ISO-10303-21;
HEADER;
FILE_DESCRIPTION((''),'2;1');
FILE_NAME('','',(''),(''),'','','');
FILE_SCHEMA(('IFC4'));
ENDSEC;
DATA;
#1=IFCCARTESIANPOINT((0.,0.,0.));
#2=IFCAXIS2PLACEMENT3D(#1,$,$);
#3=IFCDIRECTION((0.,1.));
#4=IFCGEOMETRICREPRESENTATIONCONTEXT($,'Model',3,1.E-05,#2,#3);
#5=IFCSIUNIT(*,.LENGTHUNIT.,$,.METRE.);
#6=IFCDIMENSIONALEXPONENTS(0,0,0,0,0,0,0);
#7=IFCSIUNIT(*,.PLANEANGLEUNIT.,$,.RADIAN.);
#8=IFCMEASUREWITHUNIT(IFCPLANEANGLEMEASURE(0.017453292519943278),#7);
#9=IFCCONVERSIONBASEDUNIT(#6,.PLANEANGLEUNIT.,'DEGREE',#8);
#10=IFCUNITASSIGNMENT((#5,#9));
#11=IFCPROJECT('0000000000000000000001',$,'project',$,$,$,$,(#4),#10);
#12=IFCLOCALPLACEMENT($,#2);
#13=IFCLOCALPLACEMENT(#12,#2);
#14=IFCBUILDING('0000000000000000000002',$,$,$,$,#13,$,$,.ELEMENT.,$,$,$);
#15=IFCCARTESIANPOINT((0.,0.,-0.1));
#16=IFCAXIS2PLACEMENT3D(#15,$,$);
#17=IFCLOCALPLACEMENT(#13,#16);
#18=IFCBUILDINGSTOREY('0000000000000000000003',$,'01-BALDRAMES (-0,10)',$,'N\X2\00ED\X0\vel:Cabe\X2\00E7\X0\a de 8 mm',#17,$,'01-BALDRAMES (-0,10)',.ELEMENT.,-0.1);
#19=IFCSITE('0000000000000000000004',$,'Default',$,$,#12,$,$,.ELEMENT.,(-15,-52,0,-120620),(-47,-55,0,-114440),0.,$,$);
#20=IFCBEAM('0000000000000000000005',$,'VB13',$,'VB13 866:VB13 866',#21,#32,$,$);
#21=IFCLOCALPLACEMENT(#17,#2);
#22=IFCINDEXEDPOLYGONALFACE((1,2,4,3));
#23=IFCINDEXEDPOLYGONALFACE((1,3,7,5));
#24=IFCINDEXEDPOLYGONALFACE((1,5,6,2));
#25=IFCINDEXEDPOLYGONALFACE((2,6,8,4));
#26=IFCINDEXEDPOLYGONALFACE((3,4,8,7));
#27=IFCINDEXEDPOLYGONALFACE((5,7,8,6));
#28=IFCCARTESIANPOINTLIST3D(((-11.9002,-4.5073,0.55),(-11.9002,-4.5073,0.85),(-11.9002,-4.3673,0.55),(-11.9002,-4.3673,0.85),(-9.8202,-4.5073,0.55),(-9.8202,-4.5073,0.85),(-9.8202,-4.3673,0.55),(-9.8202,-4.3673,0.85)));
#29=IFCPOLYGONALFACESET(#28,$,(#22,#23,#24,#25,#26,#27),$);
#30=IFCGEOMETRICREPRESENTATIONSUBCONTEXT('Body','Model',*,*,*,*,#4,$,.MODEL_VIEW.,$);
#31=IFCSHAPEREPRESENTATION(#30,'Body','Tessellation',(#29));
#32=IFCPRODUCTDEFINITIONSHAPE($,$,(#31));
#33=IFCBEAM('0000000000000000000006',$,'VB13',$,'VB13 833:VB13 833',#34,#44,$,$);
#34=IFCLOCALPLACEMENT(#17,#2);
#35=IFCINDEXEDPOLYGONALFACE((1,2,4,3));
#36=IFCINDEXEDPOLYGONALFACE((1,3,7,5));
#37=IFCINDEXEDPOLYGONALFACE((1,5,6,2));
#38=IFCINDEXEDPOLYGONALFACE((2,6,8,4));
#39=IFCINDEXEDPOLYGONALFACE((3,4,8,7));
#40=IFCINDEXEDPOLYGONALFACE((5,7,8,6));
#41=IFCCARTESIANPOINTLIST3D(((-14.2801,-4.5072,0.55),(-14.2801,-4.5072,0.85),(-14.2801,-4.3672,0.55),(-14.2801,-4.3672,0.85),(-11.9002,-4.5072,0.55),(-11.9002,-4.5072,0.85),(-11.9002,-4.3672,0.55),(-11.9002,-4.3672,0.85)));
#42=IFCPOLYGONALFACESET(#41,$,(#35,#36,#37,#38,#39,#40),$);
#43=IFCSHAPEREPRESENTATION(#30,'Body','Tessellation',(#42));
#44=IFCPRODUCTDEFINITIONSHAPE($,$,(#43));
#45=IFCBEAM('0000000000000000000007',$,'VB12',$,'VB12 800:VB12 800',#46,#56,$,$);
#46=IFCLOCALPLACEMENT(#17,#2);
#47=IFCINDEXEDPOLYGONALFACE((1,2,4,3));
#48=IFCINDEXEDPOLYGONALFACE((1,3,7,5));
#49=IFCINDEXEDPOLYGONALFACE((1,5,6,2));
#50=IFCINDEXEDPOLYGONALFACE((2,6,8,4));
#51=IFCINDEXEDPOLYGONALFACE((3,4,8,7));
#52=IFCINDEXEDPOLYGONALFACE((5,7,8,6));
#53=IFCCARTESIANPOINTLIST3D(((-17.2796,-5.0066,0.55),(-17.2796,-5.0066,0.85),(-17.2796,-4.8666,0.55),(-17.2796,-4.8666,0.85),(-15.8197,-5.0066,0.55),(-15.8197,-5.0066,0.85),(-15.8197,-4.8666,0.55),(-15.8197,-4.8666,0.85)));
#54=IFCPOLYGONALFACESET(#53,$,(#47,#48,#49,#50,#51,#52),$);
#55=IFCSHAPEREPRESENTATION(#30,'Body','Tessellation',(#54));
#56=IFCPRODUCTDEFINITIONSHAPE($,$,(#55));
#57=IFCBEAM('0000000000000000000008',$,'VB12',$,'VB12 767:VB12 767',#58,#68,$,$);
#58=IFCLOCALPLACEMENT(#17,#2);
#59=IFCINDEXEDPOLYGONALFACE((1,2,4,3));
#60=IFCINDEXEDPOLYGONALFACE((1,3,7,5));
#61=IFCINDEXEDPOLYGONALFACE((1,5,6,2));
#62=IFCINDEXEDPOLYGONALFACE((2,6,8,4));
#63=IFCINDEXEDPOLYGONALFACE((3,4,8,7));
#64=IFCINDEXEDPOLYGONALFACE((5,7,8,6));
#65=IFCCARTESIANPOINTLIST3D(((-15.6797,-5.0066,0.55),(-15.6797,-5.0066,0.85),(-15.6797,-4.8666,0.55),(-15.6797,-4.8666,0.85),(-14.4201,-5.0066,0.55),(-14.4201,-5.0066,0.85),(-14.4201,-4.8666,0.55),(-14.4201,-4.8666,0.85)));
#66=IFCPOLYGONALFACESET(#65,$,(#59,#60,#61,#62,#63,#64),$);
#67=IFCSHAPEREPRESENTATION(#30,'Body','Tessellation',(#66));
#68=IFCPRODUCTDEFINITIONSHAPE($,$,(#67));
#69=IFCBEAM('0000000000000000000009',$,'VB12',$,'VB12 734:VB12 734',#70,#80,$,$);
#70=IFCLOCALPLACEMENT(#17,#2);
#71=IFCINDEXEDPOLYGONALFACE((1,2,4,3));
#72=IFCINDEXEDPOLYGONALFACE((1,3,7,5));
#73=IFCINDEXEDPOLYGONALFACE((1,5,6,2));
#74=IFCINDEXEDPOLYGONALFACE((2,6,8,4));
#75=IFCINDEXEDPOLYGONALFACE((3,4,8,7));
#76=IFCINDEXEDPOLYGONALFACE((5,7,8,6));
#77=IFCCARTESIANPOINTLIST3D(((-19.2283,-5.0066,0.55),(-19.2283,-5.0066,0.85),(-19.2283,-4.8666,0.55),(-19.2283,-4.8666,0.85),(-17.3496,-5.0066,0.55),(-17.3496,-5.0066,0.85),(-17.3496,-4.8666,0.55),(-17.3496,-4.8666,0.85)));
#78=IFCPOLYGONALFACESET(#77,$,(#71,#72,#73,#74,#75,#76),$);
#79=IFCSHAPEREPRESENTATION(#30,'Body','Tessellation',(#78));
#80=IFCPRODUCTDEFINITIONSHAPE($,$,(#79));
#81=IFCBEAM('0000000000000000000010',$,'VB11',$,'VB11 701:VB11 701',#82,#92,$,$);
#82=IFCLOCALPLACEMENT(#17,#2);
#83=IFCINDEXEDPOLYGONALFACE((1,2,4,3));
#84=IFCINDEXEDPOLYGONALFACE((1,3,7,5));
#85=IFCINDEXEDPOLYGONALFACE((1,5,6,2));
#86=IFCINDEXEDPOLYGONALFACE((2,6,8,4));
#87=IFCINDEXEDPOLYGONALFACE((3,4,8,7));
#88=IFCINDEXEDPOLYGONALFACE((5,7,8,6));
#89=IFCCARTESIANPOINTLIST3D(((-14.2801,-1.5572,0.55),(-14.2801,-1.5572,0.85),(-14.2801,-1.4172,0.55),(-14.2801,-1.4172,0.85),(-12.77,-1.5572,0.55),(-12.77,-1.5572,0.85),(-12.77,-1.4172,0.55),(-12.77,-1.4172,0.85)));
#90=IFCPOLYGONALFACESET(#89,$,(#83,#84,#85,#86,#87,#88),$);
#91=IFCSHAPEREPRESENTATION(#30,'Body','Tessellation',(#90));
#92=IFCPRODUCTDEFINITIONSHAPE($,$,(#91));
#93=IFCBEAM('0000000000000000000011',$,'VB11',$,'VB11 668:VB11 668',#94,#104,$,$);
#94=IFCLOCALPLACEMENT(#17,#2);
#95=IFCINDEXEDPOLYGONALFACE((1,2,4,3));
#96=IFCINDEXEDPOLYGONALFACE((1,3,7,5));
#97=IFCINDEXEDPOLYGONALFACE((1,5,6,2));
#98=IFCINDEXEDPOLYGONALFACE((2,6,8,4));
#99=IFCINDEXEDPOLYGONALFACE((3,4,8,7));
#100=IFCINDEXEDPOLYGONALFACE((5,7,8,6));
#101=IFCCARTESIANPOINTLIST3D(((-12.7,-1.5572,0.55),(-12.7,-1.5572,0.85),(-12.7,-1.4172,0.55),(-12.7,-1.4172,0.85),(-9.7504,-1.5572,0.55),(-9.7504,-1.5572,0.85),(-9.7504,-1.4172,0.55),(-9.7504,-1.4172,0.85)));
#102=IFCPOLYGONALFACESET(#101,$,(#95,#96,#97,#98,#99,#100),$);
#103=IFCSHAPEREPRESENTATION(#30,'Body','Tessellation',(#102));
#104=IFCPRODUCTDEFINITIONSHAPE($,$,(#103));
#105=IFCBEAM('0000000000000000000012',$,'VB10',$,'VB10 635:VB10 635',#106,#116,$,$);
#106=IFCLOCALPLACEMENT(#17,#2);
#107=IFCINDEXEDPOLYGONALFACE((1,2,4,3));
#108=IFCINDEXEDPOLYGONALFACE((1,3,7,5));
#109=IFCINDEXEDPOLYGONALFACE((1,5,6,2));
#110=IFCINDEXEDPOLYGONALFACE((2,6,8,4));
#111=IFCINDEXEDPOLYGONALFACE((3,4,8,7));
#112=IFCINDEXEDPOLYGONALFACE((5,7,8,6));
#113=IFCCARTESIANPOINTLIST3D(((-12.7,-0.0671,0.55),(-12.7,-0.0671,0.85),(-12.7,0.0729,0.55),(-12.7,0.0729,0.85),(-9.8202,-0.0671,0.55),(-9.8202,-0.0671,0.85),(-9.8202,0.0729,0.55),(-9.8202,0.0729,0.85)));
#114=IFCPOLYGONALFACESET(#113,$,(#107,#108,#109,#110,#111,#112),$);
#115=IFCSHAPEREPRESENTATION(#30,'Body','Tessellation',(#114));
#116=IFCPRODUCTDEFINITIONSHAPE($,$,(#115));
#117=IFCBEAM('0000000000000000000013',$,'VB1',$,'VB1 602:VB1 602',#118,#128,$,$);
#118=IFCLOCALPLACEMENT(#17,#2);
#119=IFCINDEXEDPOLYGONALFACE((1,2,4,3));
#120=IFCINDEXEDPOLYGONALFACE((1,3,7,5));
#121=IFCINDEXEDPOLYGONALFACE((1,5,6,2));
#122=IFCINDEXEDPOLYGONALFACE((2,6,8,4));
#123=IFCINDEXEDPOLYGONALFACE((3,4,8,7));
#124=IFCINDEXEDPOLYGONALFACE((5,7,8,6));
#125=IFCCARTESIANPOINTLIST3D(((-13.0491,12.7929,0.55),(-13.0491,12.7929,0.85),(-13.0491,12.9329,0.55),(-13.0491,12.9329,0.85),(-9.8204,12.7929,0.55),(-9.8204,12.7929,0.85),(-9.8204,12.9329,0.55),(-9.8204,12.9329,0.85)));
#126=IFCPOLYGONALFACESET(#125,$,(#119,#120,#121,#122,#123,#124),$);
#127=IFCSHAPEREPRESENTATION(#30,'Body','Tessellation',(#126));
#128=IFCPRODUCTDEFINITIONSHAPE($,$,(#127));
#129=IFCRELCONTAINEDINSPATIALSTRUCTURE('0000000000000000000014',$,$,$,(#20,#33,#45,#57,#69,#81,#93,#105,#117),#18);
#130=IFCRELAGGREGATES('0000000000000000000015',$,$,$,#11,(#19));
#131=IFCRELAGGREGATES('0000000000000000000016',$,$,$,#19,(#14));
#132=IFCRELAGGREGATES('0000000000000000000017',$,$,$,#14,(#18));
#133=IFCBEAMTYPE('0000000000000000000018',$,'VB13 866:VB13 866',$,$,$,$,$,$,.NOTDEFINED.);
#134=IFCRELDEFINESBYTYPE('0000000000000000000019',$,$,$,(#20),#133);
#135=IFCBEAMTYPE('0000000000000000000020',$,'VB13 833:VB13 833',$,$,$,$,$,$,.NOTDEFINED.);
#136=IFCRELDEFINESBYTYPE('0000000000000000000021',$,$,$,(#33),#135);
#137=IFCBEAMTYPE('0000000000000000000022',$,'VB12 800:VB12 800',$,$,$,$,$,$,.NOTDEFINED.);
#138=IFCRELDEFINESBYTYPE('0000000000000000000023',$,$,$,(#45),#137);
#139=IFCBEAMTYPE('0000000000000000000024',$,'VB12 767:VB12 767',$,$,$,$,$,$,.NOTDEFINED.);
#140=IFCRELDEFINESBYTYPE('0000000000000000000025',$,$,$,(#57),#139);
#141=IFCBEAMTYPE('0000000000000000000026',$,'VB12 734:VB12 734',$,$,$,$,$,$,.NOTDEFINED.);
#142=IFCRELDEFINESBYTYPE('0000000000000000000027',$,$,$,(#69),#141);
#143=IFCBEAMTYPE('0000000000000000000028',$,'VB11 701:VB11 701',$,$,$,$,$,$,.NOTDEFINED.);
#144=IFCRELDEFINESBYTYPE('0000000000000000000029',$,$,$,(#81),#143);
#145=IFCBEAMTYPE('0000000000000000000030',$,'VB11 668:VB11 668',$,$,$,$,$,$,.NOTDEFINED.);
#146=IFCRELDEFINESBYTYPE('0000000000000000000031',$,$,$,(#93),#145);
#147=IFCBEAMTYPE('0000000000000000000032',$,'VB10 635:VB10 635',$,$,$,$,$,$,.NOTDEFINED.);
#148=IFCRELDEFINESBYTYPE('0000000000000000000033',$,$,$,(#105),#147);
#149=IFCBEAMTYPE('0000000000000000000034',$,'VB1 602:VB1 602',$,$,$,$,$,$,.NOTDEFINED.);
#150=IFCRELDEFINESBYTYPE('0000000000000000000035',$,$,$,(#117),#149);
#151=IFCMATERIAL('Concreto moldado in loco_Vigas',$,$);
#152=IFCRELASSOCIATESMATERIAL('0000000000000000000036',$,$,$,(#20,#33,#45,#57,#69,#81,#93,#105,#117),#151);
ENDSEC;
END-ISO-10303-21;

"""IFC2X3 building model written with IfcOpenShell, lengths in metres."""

from ifc_helpers import new_model, entity, si_unit, converted_unit, direction, frame, frame_2d, origin, origin_2d_with_axis, place, context, subcontext, project, spatial, rectangle, extrude, material, type_object, element, save


model = new_model("IFC2X3")

# Units and contexts
model_context = context("Model", 3, precision=1e-05, world=origin(), true_north=direction((0.0, 1.0)))
body_context = subcontext(model_context, "Body", "Model", "MODEL_VIEW")
ifc_project = project(units=[si_unit("LENGTHUNIT", "METRE"), converted_unit("PLANEANGLEUNIT", "DEGREE", entity("IfcPlaneAngleMeasure", 0.017453292519943278), si_unit("PLANEANGLEUNIT", "RADIAN"), dimensions=[0, 0, 0, 0, 0, 0, 0])], contexts=[model_context])

# Site, building, storey
site_placement = place(None, origin())
site = spatial("IfcSite", under=ifc_project, at=site_placement, Name="Default", CompositionType="ELEMENT", RefLatitude=(-15, -52, 0, -120620), RefLongitude=(-47, -55, 0, -114440), RefElevation=0.0)
building_placement = place(site_placement, origin())
building = spatial("IfcBuilding", under=site, at=building_placement, CompositionType="ELEMENT")
storey_placement = place(building_placement, frame((0.0, 0.0, -0.1)))
storey = spatial("IfcBuildingStorey", under=building, at=storey_placement, Name="01-BALDRAMES (-0,10)", ObjectType="Nível:Cabeça de 8 mm", LongName="01-BALDRAMES (-0,10)", CompositionType="ELEMENT", Elevation=-0.1)

# Beams
ifc_material = material(Name="Concreto moldado in loco_Vigas")
beam_type_1 = type_object("IfcBeamType", Name="VB13 866:VB13 866", PredefinedType="NOTDEFINED")
beam_1_placement = place(storey_placement, origin())
element("IfcBeam", 1, at=beam_1_placement, inside=storey, type_object=beam_type_1, material=ifc_material, Name="VB13", ObjectType="VB13 866:VB13 866", context=body_context, shape_type="SweptSolid", body=[
    extrude(rectangle(XDim=0.3, YDim=0.14, at=frame_2d((0.0, 0.0), x_axis=(1.0, 0.0))), frame((-11.9002, -4.4373, 0.7), z_axis=(1.0, 0.0, 0.0), x_axis=(0.0, 0.0, -1.0)), (0.0, 0.0, 1.0), 2.08),
])
beam_type_2 = type_object("IfcBeamType", Name="VB13 833:VB13 833", PredefinedType="NOTDEFINED")
beam_2_placement = place(storey_placement, origin())
element("IfcBeam", 2, at=beam_2_placement, inside=storey, type_object=beam_type_2, material=ifc_material, Name="VB13", ObjectType="VB13 833:VB13 833", context=body_context, shape_type="SweptSolid", body=[
    extrude(rectangle(XDim=0.3, YDim=0.14, at=frame_2d((0.0, 0.0), x_axis=(1.0, 0.0))), frame((-14.2801, -4.4372, 0.7), z_axis=(1.0, 0.0, 0.0), x_axis=(0.0, 0.0, -1.0)), (0.0, 0.0, 1.0), 2.3799),
])
beam_type_3 = type_object("IfcBeamType", Name="VB12 800:VB12 800", PredefinedType="NOTDEFINED")
beam_3_placement = place(storey_placement, origin())
element("IfcBeam", 3, at=beam_3_placement, inside=storey, type_object=beam_type_3, material=ifc_material, Name="VB12", ObjectType="VB12 800:VB12 800", context=body_context, shape_type="SweptSolid", body=[
    extrude(rectangle(XDim=0.3, YDim=0.14, at=frame_2d((0.0, 0.0), x_axis=(1.0, 0.0))), frame((-17.2796, -4.9366, 0.7), z_axis=(1.0, 0.0, 0.0), x_axis=(0.0, 0.0, -1.0)), (0.0, 0.0, 1.0), 1.4599),
])
beam_type_4 = type_object("IfcBeamType", Name="VB12 767:VB12 767", PredefinedType="NOTDEFINED")
beam_4_placement = place(storey_placement, origin())
element("IfcBeam", 4, at=beam_4_placement, inside=storey, type_object=beam_type_4, material=ifc_material, Name="VB12", ObjectType="VB12 767:VB12 767", context=body_context, shape_type="SweptSolid", body=[
    extrude(rectangle(XDim=0.3, YDim=0.14, at=frame_2d((0.0, 0.0), x_axis=(1.0, 0.0))), frame((-15.6797, -4.9366, 0.7), z_axis=(1.0, 0.0, 0.0), x_axis=(0.0, 0.0, -1.0)), (0.0, 0.0, 1.0), 1.2596),
])
beam_type_5 = type_object("IfcBeamType", Name="VB12 734:VB12 734", PredefinedType="NOTDEFINED")
beam_5_placement = place(storey_placement, origin())
element("IfcBeam", 5, at=beam_5_placement, inside=storey, type_object=beam_type_5, material=ifc_material, Name="VB12", ObjectType="VB12 734:VB12 734", context=body_context, shape_type="SweptSolid", body=[
    extrude(rectangle(XDim=0.3, YDim=0.14, at=frame_2d((0.0, 0.0), x_axis=(1.0, 0.0))), frame((-19.2283, -4.9366, 0.7), z_axis=(1.0, 0.0, 0.0), x_axis=(0.0, 0.0, -1.0)), (0.0, 0.0, 1.0), 1.8787),
])
beam_type_6 = type_object("IfcBeamType", Name="VB11 701:VB11 701", PredefinedType="NOTDEFINED")
beam_6_placement = place(storey_placement, origin())
element("IfcBeam", 6, at=beam_6_placement, inside=storey, type_object=beam_type_6, material=ifc_material, Name="VB11", ObjectType="VB11 701:VB11 701", context=body_context, shape_type="SweptSolid", body=[
    extrude(rectangle(XDim=0.3, YDim=0.14, at=origin_2d_with_axis()), frame((-14.2801, -1.4872, 0.7), z_axis=(1.0, 0.0, 0.0), x_axis=(0.0, 0.0, -1.0)), (0.0, 0.0, 1.0), 1.5101),
])
beam_type_7 = type_object("IfcBeamType", Name="VB11 668:VB11 668", PredefinedType="NOTDEFINED")
beam_7_placement = place(storey_placement, origin())
element("IfcBeam", 7, at=beam_7_placement, inside=storey, type_object=beam_type_7, material=ifc_material, Name="VB11", ObjectType="VB11 668:VB11 668", context=body_context, shape_type="SweptSolid", body=[
    extrude(rectangle(XDim=0.3, YDim=0.14, at=origin_2d_with_axis()), frame((-12.7, -1.4872, 0.7), z_axis=(1.0, 0.0, 0.0), x_axis=(0.0, 0.0, -1.0)), (0.0, 0.0, 1.0), 2.9496),
])
beam_type_8 = type_object("IfcBeamType", Name="VB10 635:VB10 635", PredefinedType="NOTDEFINED")
beam_8_placement = place(storey_placement, origin())
element("IfcBeam", 8, at=beam_8_placement, inside=storey, type_object=beam_type_8, material=ifc_material, Name="VB10", ObjectType="VB10 635:VB10 635", context=body_context, shape_type="SweptSolid", body=[
    extrude(rectangle(XDim=0.3, YDim=0.14, at=origin_2d_with_axis()), frame((-12.7, 0.0029, 0.7), z_axis=(1.0, 0.0, 0.0), x_axis=(0.0, 0.0, -1.0)), (0.0, 0.0, 1.0), 2.8798),
])
beam_type_9 = type_object("IfcBeamType", Name="VB1 602:VB1 602", PredefinedType="NOTDEFINED")
beam_9_placement = place(storey_placement, origin())
element("IfcBeam", 9, at=beam_9_placement, inside=storey, type_object=beam_type_9, material=ifc_material, Name="VB1", ObjectType="VB1 602:VB1 602", context=body_context, shape_type="SweptSolid", body=[
    extrude(rectangle(XDim=0.3, YDim=0.14, at=frame_2d((0.0, 0.0), x_axis=(1.0, 0.0))), frame((-13.0491, 12.8629, 0.7), z_axis=(1.0, 0.0, 0.0), x_axis=(0.0, 0.0, -1.0)), (0.0, 0.0, 1.0), 3.2287),
])

save(model, "model.ifc")
